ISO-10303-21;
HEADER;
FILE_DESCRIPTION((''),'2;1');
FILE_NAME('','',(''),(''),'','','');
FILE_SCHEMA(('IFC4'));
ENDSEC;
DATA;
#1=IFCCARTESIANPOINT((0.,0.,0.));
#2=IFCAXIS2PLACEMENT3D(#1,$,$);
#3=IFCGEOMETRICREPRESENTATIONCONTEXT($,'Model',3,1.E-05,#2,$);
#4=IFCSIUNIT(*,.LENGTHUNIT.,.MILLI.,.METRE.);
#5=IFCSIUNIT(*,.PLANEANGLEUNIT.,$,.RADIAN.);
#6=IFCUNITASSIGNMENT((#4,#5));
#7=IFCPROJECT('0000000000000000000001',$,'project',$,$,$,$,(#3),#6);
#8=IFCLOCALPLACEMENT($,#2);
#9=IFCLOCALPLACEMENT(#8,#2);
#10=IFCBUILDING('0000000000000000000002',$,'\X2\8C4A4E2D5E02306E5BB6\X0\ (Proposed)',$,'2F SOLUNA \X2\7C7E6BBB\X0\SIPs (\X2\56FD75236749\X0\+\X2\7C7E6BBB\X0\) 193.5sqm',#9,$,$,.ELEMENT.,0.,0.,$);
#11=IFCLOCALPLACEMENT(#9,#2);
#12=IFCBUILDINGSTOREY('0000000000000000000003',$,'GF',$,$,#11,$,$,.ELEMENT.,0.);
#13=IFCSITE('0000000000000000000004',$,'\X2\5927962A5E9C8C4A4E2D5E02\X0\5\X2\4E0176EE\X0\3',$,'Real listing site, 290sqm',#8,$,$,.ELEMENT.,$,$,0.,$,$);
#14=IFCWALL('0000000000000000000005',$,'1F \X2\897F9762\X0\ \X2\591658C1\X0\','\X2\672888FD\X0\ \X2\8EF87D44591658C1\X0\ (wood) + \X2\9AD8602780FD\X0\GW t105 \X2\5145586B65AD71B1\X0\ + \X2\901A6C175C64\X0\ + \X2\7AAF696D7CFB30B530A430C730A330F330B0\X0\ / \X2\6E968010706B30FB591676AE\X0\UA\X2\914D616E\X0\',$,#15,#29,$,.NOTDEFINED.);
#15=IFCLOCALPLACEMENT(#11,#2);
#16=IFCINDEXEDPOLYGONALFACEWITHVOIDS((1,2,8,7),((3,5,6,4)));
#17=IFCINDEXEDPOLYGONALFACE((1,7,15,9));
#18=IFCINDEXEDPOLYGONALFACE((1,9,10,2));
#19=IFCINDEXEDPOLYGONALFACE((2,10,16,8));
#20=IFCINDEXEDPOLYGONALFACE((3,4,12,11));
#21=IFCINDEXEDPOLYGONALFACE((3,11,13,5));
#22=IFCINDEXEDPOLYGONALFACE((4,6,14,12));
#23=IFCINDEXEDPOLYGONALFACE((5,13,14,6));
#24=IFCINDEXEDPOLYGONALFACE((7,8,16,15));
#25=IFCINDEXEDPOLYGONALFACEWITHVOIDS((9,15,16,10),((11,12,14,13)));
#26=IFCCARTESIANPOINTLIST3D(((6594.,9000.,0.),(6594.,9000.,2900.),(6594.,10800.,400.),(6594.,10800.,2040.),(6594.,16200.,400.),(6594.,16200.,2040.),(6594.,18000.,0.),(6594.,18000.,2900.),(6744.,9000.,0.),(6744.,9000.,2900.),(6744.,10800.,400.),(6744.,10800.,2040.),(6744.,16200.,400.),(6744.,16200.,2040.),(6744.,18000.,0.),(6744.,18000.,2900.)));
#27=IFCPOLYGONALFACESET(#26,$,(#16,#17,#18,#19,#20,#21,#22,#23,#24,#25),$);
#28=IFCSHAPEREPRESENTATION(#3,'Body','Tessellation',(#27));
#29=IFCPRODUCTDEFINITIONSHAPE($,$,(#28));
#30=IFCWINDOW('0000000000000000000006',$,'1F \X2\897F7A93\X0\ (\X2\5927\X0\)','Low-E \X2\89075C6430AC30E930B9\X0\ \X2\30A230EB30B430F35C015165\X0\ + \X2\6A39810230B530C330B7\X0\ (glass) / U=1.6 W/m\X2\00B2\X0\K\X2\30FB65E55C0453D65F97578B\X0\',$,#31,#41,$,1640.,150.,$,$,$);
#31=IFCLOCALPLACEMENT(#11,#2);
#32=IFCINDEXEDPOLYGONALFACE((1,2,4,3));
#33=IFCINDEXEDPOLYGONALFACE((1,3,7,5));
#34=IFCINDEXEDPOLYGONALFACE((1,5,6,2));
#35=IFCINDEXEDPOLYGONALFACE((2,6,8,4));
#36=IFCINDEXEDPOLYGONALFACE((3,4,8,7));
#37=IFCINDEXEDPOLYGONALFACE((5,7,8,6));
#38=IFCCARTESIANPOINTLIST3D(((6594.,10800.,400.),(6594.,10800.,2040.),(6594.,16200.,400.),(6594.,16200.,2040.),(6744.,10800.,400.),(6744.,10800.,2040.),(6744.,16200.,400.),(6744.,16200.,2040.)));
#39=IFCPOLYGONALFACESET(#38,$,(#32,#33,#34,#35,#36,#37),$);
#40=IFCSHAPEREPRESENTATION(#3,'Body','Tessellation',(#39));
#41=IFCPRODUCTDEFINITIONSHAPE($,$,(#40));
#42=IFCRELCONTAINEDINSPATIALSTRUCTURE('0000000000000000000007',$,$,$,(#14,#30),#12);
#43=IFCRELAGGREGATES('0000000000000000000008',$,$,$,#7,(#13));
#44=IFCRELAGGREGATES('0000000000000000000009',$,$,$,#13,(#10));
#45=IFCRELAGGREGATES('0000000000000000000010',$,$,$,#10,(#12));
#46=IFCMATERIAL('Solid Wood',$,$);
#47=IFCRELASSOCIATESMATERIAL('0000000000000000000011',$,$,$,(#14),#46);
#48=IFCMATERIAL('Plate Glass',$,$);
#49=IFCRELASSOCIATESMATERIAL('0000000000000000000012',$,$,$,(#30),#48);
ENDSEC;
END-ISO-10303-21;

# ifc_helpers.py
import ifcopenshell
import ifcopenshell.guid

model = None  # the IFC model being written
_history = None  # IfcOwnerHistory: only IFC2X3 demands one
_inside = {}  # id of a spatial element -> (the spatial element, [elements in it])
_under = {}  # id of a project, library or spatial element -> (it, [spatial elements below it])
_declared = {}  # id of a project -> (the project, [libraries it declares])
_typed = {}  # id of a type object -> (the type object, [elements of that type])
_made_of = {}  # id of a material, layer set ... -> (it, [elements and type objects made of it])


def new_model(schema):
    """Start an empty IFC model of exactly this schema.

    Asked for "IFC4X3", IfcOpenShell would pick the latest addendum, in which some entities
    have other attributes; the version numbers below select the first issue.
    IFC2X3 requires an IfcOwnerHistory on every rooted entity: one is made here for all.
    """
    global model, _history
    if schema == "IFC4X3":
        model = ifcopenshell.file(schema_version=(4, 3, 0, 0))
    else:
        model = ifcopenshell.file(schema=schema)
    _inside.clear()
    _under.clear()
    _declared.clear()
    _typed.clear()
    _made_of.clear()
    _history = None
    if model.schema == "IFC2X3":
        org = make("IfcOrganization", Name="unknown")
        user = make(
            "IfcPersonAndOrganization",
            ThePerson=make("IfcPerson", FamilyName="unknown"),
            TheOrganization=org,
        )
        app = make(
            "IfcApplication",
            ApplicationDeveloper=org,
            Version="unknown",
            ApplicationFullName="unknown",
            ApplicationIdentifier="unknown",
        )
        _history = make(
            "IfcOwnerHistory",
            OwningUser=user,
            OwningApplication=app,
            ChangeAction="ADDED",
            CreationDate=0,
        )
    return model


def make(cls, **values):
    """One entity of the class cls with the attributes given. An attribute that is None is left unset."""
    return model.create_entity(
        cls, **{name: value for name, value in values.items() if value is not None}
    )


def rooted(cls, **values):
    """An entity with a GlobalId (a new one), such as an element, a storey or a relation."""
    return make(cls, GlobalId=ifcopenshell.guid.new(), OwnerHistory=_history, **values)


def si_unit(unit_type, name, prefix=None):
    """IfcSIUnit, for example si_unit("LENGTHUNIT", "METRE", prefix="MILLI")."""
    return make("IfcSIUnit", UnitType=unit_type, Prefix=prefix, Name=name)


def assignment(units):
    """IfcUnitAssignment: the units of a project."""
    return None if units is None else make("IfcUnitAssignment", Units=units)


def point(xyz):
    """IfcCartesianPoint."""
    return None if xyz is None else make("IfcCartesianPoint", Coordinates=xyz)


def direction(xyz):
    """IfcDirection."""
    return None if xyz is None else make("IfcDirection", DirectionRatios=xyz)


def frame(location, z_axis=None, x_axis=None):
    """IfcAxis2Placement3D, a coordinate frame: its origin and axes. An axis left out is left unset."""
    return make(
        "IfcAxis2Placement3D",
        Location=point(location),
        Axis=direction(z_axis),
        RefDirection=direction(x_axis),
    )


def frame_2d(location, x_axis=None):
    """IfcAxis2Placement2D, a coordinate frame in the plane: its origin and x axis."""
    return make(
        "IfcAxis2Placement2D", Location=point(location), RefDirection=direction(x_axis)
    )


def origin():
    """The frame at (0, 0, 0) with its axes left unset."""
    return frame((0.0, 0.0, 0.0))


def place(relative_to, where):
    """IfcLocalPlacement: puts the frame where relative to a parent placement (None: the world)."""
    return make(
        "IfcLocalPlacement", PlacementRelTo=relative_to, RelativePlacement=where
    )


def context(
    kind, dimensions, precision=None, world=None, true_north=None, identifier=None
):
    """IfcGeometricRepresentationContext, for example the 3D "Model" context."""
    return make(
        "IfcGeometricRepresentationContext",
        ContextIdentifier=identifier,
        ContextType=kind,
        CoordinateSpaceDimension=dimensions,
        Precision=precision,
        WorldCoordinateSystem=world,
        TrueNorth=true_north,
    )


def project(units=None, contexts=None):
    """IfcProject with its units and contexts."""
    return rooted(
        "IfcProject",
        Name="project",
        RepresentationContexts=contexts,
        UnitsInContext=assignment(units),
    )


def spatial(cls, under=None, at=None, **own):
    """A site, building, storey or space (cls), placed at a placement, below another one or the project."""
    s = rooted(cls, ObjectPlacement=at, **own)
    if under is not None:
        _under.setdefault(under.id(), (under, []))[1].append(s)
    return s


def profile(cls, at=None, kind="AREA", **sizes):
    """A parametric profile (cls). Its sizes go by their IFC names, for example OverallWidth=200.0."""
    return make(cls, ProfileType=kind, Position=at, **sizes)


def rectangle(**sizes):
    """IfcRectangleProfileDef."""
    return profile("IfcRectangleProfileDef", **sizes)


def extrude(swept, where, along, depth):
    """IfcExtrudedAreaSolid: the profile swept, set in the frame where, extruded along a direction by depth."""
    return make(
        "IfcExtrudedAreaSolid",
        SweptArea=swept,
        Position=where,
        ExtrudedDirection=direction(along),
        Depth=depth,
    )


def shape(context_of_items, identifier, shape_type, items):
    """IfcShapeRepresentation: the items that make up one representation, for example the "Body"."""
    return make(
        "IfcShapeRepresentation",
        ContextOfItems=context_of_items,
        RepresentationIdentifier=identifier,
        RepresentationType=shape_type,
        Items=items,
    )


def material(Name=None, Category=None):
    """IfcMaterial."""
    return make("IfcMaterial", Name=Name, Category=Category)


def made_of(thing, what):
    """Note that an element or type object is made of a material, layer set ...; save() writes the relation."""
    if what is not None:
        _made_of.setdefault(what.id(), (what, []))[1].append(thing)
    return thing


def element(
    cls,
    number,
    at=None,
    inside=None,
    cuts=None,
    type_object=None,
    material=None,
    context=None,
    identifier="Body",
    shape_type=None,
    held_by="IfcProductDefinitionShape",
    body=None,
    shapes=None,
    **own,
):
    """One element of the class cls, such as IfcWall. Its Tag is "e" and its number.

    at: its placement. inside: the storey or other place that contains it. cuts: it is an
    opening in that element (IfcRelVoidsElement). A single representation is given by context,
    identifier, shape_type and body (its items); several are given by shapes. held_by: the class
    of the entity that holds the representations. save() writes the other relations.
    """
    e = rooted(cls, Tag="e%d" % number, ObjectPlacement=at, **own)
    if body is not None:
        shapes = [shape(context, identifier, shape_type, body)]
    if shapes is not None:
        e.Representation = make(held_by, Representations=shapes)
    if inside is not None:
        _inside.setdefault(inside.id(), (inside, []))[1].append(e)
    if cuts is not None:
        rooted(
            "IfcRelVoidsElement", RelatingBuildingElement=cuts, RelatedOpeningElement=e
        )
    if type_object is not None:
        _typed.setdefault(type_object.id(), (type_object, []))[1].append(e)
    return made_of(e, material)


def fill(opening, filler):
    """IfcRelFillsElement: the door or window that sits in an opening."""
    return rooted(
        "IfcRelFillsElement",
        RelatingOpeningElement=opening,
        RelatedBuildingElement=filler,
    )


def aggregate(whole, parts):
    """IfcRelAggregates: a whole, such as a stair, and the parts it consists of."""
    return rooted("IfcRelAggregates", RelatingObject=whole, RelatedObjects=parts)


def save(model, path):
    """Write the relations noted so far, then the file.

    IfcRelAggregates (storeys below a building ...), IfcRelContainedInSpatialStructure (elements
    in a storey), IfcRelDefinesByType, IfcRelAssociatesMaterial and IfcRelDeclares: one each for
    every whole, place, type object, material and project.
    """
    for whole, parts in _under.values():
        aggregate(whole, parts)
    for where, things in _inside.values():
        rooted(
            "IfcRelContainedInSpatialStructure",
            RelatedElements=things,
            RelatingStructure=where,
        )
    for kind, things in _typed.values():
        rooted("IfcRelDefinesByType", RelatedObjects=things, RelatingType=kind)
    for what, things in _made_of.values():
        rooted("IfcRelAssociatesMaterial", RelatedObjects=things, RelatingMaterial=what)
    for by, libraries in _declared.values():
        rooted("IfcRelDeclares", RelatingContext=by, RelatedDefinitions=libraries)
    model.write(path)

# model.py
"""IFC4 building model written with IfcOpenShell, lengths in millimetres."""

from ifc_helpers import new_model, si_unit, frame, frame_2d, origin, place, context, project, spatial, rectangle, extrude, material, element, fill, save


model = new_model("IFC4")

# Units and contexts
model_context = context("Model", 3, precision=1e-05, world=origin())
ifc_project = project(units=[si_unit("LENGTHUNIT", "METRE", prefix="MILLI"), si_unit("PLANEANGLEUNIT", "RADIAN")], contexts=[model_context])

# Site, building, storey
site_placement = place(None, origin())
site = spatial("IfcSite", under=ifc_project, at=site_placement, Name="大阪府豊中市5丁目3", ObjectType="Real listing site, 290sqm", CompositionType="ELEMENT", RefElevation=0.0)
building_placement = place(site_placement, origin())
building = spatial("IfcBuilding", under=site, at=building_placement, Name="豊中市の家 (Proposed)", ObjectType="2F SOLUNA 籾殻SIPs (国産杉+籾殻) 193.5sqm", CompositionType="ELEMENT", ElevationOfRefHeight=0.0, ElevationOfTerrain=0.0)
storey_placement = place(building_placement, origin())
storey = spatial("IfcBuildingStorey", under=building, at=storey_placement, Name="GF", CompositionType="ELEMENT", Elevation=0.0)

# Shared definitions
ifc_material_1 = material(Name="Solid Wood")

# Shared definitions
ifc_material_2 = material(Name="Plate Glass")

# Wall, opening, window
wall_1_placement = place(storey_placement, frame((3297.0, 4500.0, 0.0)))
wall_1 = element("IfcWall", 1, at=wall_1_placement, inside=storey, material=ifc_material_1, Name="1F 西面 外壁", Description="木製 軸組外壁 (wood) + 高性能GW t105 充填断熱 + 通気層 + 窯業系サイディング / 準耐火・外皮UA配慮", PredefinedType="NOTDEFINED", context=model_context, shape_type="SweptSolid", body=[
    extrude(rectangle(XDim=150.0, YDim=9000.0, at=frame_2d((75.0, 4500.0))), frame((3297.0, 4500.0, 0.0)), (0.0, 0.0, 1.0), 2900.0),
])
opening_1_placement = place(storey_placement, frame((3297.0, 5400.0, 200.0)))
opening_1 = element("IfcOpeningElement", 2, at=opening_1_placement, cuts=wall_1, PredefinedType="NOTDEFINED", context=model_context, shape_type="SweptSolid", body=[
    extrude(rectangle(XDim=150.0, YDim=5400.0, at=frame_2d((75.0, 2700.0))), frame((3297.0, 5400.0, 200.0)), (0.0, 0.0, 1.0), 1640.0),
])
window_1_placement = place(storey_placement, frame((3297.0, 5400.0, 200.0)))
window_1 = element("IfcWindow", 3, at=window_1_placement, inside=storey, material=ifc_material_2, Name="1F 西窓 (大)", Description="Low-E 複層ガラス アルゴン封入 + 樹脂サッシ (glass) / U=1.6 W/m²K・日射取得型", OverallHeight=1640.0, OverallWidth=150.0, context=model_context, shape_type="SweptSolid", body=[
    extrude(rectangle(XDim=150.0, YDim=5400.0, at=frame_2d((75.0, 2700.0))), frame((3297.0, 5400.0, 200.0)), (0.0, 0.0, 1.0), 1640.0),
])
fill(opening_1, window_1)

save(model, "model.ifc")
